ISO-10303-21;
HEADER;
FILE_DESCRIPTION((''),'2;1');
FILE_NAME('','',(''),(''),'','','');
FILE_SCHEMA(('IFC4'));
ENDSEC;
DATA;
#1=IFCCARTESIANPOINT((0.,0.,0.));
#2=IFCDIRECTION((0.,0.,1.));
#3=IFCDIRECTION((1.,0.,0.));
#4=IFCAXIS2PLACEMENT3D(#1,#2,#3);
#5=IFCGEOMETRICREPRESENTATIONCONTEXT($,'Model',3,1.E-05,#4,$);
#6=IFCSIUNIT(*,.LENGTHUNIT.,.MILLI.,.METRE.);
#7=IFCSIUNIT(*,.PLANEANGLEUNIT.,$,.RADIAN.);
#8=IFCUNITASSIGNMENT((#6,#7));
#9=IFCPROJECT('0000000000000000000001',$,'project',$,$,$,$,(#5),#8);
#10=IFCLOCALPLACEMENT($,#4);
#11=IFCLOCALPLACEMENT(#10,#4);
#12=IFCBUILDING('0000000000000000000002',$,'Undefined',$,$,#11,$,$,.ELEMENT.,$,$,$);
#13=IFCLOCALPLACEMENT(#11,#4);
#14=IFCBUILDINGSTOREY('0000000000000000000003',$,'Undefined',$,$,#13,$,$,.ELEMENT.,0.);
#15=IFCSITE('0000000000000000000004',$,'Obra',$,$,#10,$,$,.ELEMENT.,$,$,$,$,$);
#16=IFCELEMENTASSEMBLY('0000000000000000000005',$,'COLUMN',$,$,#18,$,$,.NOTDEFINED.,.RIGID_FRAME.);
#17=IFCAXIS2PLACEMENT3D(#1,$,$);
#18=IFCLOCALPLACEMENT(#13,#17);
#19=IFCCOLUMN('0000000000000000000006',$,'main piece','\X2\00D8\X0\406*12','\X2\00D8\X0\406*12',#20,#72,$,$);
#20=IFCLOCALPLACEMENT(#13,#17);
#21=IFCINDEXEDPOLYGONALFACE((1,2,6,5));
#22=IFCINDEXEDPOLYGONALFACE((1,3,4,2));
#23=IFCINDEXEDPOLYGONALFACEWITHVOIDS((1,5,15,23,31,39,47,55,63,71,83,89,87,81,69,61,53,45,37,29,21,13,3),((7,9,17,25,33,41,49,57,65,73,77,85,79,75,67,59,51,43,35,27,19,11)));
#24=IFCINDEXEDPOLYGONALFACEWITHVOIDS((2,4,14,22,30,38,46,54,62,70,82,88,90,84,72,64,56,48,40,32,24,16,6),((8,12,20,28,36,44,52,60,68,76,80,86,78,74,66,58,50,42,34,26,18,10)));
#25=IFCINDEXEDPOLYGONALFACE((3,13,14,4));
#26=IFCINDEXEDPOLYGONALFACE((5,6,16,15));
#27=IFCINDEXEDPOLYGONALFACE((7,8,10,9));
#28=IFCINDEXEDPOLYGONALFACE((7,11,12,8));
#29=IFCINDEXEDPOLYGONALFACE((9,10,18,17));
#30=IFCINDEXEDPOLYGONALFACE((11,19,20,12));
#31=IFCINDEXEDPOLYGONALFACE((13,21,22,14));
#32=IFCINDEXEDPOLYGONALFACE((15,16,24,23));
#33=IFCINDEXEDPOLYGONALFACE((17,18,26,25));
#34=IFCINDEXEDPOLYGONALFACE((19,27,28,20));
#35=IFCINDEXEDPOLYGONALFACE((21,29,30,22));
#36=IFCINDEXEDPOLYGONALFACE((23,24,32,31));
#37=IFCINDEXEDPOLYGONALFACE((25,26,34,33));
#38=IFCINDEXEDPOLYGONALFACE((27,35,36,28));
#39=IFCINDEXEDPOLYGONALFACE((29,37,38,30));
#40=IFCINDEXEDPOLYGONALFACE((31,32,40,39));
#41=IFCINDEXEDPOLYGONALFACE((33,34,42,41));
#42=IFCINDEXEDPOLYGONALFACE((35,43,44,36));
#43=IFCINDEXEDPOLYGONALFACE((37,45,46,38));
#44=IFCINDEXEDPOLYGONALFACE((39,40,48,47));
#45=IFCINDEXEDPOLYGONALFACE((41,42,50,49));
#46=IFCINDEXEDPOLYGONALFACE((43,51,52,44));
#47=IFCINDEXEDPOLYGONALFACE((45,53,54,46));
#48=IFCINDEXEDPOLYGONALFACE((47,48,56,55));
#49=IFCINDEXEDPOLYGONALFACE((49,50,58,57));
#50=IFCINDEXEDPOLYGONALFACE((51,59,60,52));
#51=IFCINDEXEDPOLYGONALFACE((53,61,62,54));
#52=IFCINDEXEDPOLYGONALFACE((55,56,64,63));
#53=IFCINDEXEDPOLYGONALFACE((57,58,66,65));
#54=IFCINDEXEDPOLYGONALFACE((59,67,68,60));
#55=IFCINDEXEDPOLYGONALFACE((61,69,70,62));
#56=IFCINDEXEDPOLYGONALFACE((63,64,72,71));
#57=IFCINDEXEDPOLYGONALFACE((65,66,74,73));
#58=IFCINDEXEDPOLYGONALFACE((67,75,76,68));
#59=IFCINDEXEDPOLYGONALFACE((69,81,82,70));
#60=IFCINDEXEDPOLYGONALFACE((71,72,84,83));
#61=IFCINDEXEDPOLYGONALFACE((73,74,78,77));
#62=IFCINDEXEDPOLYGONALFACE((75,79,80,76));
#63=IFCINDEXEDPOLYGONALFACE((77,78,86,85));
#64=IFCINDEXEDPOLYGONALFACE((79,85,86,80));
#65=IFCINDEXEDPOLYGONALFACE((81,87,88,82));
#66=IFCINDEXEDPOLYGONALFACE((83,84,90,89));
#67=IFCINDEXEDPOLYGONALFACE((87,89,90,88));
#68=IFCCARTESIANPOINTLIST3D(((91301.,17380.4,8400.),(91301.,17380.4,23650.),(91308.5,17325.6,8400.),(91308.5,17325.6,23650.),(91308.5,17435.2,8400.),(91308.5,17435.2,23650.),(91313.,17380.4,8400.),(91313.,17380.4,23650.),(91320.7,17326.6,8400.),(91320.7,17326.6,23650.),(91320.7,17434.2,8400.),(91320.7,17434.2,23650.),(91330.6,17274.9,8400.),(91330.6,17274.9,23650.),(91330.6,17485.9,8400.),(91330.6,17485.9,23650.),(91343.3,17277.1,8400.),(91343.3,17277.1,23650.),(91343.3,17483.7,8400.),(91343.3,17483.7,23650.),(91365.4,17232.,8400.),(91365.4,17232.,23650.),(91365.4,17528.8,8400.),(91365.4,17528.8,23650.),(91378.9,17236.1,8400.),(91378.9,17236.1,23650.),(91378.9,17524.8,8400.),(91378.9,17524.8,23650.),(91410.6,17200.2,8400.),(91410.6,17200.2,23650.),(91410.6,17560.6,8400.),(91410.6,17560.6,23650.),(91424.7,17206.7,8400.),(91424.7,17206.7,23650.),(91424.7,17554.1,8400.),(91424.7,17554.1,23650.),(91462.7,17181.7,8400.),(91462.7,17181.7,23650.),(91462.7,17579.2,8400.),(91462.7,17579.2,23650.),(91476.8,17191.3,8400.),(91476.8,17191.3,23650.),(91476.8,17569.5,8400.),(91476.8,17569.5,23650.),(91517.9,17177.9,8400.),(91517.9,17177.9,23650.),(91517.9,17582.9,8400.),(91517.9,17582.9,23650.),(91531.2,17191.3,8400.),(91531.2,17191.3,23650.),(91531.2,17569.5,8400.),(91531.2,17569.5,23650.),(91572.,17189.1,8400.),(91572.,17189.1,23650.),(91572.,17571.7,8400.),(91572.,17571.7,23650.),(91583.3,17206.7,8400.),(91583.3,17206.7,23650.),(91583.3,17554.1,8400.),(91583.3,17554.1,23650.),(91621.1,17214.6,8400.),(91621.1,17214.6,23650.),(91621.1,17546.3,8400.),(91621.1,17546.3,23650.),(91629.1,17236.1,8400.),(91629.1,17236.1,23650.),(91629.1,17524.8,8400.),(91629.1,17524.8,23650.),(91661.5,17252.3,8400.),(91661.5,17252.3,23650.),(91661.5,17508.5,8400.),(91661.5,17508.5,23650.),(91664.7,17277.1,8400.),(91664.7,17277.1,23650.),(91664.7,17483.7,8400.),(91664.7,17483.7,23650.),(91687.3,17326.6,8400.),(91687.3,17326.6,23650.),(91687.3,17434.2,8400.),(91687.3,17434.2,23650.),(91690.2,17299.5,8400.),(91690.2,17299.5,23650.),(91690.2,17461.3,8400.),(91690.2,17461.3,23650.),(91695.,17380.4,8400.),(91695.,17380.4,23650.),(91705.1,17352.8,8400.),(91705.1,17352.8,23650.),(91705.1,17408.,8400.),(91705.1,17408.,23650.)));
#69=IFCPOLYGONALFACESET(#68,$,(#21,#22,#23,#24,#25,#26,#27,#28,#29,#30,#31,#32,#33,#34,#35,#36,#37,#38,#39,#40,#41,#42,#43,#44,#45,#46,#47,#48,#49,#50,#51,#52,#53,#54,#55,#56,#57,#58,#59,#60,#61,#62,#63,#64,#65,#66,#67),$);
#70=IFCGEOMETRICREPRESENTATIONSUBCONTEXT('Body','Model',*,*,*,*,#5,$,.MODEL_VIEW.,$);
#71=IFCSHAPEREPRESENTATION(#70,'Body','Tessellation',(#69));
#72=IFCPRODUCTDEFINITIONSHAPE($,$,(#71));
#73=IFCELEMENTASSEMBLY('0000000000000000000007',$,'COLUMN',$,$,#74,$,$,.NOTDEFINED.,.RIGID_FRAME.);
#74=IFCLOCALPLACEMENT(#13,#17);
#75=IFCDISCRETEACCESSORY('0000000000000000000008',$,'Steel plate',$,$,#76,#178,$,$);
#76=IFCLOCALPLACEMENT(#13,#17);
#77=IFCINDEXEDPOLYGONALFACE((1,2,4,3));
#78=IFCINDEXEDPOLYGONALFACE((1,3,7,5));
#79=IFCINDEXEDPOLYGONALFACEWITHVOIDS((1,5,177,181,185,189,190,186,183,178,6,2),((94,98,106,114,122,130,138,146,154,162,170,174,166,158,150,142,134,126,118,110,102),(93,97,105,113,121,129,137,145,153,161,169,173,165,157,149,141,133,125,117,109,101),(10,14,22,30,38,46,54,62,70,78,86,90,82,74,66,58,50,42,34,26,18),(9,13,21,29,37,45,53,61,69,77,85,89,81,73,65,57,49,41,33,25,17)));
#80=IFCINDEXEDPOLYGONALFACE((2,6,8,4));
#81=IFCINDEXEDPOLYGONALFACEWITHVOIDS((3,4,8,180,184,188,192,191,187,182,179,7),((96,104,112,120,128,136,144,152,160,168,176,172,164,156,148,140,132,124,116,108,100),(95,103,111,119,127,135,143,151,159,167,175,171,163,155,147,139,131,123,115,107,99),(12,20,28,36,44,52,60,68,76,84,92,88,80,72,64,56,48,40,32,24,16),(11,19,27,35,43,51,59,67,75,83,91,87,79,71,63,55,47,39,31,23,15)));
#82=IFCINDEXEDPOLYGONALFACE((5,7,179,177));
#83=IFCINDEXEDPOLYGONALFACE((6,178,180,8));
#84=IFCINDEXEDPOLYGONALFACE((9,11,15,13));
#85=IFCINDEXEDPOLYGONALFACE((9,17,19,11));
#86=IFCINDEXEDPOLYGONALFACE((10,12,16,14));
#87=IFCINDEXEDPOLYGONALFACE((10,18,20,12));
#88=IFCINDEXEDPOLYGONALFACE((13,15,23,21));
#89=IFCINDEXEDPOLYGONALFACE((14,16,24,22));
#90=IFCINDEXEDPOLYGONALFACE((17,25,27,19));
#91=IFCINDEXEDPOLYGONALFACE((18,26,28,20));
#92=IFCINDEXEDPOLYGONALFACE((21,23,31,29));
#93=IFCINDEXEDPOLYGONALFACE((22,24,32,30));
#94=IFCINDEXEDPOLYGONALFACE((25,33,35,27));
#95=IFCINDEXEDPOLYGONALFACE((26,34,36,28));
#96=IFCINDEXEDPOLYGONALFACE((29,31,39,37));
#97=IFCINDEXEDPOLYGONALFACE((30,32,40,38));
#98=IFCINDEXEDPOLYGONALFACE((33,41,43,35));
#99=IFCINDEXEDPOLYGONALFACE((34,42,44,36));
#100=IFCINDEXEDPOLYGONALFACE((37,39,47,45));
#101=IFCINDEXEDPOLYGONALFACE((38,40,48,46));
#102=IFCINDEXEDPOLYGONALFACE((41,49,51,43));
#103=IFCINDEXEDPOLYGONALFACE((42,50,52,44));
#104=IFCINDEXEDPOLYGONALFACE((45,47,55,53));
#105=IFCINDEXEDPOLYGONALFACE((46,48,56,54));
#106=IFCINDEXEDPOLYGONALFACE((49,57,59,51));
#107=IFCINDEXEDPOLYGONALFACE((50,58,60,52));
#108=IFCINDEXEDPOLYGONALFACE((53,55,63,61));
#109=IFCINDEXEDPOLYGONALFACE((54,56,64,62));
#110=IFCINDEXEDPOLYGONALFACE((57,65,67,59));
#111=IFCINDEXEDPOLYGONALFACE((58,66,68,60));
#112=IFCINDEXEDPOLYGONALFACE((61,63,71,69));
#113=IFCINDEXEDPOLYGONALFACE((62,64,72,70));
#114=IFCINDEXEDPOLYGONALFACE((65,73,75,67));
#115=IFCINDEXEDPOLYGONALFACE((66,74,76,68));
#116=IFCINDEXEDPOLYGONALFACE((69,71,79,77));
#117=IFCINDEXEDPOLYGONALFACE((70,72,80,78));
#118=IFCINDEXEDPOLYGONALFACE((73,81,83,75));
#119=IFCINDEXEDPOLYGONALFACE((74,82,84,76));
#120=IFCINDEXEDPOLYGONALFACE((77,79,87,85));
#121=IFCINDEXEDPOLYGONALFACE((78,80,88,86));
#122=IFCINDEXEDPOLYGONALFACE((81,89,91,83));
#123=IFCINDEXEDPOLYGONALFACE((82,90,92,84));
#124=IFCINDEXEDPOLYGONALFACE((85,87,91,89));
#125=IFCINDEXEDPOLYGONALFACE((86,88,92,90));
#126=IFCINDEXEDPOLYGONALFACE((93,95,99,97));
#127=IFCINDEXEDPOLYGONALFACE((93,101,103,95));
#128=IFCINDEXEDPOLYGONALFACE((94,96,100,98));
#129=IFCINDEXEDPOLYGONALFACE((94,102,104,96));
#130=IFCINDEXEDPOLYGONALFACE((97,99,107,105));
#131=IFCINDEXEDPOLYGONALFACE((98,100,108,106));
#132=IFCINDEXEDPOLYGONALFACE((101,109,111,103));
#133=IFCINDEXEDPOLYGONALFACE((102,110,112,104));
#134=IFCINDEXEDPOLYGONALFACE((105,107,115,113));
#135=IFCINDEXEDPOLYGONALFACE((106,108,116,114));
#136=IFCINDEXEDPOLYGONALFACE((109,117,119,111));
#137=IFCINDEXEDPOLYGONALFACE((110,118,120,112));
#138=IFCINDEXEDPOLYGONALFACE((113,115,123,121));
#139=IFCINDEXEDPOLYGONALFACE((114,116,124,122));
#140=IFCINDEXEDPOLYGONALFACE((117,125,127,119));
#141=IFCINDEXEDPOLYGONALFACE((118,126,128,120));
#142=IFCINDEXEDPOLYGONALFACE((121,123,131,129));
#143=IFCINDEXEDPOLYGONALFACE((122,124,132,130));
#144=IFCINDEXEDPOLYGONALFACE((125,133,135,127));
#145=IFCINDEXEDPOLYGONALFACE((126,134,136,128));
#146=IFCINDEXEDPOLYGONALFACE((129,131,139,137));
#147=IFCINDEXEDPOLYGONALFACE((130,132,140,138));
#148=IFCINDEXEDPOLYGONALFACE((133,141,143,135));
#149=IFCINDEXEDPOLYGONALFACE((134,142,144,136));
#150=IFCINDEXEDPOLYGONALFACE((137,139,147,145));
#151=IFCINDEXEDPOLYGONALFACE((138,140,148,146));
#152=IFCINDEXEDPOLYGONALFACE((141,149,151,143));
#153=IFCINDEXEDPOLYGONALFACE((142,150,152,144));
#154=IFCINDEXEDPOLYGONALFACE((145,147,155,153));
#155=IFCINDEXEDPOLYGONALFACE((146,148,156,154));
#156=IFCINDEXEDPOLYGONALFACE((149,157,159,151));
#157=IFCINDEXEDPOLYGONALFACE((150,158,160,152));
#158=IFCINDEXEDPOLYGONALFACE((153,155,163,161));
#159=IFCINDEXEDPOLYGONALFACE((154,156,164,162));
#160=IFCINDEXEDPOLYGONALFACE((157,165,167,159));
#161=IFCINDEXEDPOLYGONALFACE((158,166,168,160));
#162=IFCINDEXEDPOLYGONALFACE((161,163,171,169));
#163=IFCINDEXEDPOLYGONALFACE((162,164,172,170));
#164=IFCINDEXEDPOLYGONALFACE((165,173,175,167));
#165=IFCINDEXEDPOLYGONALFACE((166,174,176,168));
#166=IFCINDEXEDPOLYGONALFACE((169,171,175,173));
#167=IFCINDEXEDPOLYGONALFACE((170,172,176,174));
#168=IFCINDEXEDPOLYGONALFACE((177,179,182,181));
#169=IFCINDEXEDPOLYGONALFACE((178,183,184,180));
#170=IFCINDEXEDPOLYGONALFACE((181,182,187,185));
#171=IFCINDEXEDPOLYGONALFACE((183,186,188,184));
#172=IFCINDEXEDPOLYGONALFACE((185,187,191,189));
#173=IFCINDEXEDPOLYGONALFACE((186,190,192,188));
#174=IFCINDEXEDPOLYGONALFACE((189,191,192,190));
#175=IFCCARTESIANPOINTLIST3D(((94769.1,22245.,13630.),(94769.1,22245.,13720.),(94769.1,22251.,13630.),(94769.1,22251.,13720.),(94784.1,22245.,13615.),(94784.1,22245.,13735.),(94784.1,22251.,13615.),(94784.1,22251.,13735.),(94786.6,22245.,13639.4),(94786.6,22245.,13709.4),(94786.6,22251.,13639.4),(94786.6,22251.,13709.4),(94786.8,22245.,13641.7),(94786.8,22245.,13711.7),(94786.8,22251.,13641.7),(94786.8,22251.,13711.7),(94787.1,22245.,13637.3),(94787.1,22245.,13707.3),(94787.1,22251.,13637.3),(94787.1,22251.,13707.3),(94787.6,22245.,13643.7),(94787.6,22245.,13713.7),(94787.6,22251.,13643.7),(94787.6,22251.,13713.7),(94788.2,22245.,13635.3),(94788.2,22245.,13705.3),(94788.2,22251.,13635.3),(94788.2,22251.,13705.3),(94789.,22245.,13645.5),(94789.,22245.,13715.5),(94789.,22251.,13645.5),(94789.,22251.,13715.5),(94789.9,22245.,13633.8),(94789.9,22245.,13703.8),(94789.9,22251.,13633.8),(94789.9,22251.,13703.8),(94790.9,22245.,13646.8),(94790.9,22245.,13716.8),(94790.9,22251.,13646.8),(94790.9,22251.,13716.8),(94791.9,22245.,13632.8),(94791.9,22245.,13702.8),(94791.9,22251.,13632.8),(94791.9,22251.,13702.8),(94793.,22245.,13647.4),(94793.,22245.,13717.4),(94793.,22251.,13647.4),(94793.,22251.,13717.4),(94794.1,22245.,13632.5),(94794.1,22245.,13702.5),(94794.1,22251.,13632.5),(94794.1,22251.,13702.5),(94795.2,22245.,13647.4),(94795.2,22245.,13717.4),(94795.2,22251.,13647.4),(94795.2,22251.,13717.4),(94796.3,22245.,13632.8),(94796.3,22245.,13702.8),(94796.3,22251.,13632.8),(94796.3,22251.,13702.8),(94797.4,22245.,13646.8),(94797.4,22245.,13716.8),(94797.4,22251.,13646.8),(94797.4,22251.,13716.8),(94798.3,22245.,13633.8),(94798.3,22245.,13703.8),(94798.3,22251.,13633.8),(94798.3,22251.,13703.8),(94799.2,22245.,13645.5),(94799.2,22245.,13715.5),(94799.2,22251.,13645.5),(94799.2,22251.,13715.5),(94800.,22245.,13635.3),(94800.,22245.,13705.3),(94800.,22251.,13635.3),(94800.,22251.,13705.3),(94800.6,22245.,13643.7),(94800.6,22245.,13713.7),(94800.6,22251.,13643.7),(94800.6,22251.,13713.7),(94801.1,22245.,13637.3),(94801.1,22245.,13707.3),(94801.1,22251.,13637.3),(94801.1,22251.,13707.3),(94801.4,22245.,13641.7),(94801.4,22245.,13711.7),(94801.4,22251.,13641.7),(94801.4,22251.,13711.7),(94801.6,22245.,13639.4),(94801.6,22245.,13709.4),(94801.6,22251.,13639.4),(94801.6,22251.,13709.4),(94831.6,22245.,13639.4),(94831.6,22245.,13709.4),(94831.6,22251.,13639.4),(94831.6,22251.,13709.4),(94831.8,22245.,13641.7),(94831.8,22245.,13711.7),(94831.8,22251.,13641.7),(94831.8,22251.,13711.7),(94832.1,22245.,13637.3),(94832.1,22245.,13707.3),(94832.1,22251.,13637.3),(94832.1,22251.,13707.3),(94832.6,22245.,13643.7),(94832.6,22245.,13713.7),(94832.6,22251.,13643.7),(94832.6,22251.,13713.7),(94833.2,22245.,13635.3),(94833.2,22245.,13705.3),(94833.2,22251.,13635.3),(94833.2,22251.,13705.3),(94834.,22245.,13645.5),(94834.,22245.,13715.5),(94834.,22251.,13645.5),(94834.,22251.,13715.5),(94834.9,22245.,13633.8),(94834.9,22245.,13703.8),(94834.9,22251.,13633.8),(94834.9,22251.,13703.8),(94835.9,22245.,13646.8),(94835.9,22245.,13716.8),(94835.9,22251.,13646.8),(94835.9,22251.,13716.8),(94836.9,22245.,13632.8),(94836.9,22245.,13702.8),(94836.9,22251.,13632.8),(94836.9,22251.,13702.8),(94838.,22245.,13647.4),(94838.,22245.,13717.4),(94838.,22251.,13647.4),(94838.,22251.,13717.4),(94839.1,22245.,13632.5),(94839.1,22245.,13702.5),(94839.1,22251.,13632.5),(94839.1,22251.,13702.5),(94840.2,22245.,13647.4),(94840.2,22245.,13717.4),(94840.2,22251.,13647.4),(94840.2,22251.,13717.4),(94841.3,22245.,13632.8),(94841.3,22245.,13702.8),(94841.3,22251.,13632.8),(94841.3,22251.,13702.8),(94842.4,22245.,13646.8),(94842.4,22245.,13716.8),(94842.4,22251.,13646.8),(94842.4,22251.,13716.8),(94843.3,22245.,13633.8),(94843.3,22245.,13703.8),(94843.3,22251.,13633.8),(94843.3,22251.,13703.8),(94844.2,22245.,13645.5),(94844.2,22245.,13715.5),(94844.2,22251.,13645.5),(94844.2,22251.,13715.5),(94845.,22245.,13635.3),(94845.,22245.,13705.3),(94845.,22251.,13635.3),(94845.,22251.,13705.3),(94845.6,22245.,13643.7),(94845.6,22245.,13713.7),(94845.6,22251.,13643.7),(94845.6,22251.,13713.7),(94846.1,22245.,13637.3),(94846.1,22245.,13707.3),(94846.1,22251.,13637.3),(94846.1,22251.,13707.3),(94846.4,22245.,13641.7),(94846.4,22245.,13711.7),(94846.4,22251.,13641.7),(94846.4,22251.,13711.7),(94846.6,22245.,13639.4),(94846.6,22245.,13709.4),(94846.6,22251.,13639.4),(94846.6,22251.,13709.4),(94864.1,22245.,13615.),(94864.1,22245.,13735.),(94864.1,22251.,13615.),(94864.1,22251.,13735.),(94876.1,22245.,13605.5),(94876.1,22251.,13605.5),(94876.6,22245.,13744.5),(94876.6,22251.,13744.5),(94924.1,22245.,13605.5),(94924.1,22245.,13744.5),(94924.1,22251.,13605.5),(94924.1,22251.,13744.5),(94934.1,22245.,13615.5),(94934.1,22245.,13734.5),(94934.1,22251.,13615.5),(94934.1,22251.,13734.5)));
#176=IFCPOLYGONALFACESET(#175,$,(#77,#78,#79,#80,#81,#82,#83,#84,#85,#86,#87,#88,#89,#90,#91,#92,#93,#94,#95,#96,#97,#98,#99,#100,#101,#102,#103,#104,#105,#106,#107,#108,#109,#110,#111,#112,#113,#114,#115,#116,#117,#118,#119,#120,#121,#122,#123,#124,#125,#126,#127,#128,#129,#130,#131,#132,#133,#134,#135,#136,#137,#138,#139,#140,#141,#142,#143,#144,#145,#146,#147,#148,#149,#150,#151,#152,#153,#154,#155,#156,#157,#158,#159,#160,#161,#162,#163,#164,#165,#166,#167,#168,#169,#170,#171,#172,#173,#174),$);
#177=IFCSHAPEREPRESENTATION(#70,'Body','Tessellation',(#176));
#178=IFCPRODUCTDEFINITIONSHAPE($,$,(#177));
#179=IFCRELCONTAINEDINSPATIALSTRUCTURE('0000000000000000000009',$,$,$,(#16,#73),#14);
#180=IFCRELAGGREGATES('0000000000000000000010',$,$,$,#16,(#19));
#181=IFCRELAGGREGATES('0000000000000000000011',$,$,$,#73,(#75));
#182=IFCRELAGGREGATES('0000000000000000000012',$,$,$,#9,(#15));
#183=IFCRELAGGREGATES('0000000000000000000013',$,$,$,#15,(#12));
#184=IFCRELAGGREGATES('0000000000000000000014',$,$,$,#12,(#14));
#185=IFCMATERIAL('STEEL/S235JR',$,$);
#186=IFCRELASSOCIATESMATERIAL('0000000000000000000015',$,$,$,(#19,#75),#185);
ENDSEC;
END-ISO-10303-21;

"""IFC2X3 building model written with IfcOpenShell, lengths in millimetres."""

from ifc_helpers import new_model, si_unit, frame, origin_with_axes, origin_2d_with_axis, place, context, subcontext, project, spatial, polyline, circle, hollow_circle, outline, extrude, clip, halfspace, source, transform, mapped, material, element, aggregate, save


model = new_model("IFC2X3")

# Units and contexts
model_context = context("Model", 3, precision=1e-05, world=origin_with_axes())
body_context = subcontext(model_context, "Body", "Model", "MODEL_VIEW")
ifc_project = project(units=[si_unit("LENGTHUNIT", "METRE", prefix="MILLI"), si_unit("PLANEANGLEUNIT", "RADIAN")], contexts=[model_context])

# Site, building, storey
site_placement = place(None, origin_with_axes())
site = spatial("IfcSite", under=ifc_project, at=site_placement, Name="Obra", CompositionType="ELEMENT")
building_placement = place(site_placement, origin_with_axes())
building = spatial("IfcBuilding", under=site, at=building_placement, Name="Undefined", CompositionType="ELEMENT")
storey_placement = place(building_placement, origin_with_axes())
storey = spatial("IfcBuildingStorey", under=building, at=storey_placement, Name="Undefined", CompositionType="ELEMENT", Elevation=0.0)

# Element assembly, column
assembly_1_placement = place(storey_placement, origin_with_axes())
assembly_1 = element("IfcElementAssembly", 1, at=assembly_1_placement, inside=storey, Name="COLUMN", AssemblyPlace="NOTDEFINED", PredefinedType="RIGID_FRAME")
ifc_material_1 = material(Name="STEEL/S235JR")
column_placement = place(assembly_1_placement, frame((91504.0, 17380.4, 8384.0), z_axis=(0.0, 0.0, 1.0), x_axis=(0.0, 1.0, 0.0)))
column = element("IfcColumn", 2, at=column_placement, material=ifc_material_1, Name="main piece", Description="Ø406*12", ObjectType="Ø406*12", context=body_context, shape_type="Clipping", body=[
    clip(extrude(hollow_circle(Radius=203.0, WallThickness=12.0, at=origin_2d_with_axis()), frame((0.0, 0.0, 15266.0), z_axis=(0.0, 0.0, -1.0), x_axis=(0.0, 1.0, 0.0)), (0.0, 0.0, 1.0), 15250.0), halfspace(frame((-203.0, 0.0, 16.0), z_axis=(0.0, 0.0, 1.0), x_axis=(0.0, 1.0, 0.0)), True)),
])
aggregate(assembly_1, [column])

# Element assembly, discrete accessory, opening
assembly_2_placement = place(storey_placement, origin_with_axes())
assembly_2 = element("IfcElementAssembly", 3, at=assembly_2_placement, inside=storey, Name="COLUMN", AssemblyPlace="NOTDEFINED", PredefinedType="RIGID_FRAME")
discrete_accessory_1_placement = place(assembly_2_placement, frame((94934.1, 22248.0, 13615.5), z_axis=(0.0, 1.0, 0.0), x_axis=(-0.707107, 0.0, -0.707107)))
discrete_accessory_1 = element("IfcDiscreteAccessory", 4, at=discrete_accessory_1_placement, material=ifc_material_1, Name="Steel plate", context=body_context, shape_type="SweptSolid", body=[
    extrude(outline(polyline([(0.0, 0.0), (14.1, 0.0), (48.1, 33.9), (49.9, 49.1), (106.4, 105.7), (106.4, 126.9), (42.8, 190.6), (21.6, 190.6), (-35.0, 134.0), (-50.6, 131.9), (-84.1, 98.3), (-84.1, 84.1), (0.0, 0.0)])), frame((0.0, 0.0, -3.0), z_axis=(0.0, 0.0, 1.0), x_axis=(1.0, 0.0, 0.0)), (0.0, 0.0, 1.0), 6.0),
])
shared_shape_1 = source(origin_with_axes(), body_context, "Body", "SweptSolid", [
    extrude(circle(Radius=7.5, at=origin_2d_with_axis()), frame((0.0, 2.4, 0.0), z_axis=(0.0, 1.0, 0.0), x_axis=(1.0, 0.0, 0.0)), (0.0, 0.0, 1.0), 6.2),
])
opening_1_placement = place(assembly_2_placement, frame((94816.6, 22253.5, 13710.0), z_axis=(-1.0, 0.0, 0.0), x_axis=(0.0, 0.0, -1.0)))
element("IfcOpeningElement", 5, at=opening_1_placement, cuts=discrete_accessory_1, ObjectType="Opening", context=body_context, shape_type="MappedRepresentation", body=[
    mapped(shared_shape_1, transform((0.0, 0.0, -22.5))),
    mapped(shared_shape_1, transform((70.0, 0.0, -22.5))),
    mapped(shared_shape_1, transform((0.0, 0.0, 22.5))),
    mapped(shared_shape_1, transform((70.0, 0.0, 22.5))),
])
aggregate(assembly_2, [discrete_accessory_1])

save(model, "model.ifc")
